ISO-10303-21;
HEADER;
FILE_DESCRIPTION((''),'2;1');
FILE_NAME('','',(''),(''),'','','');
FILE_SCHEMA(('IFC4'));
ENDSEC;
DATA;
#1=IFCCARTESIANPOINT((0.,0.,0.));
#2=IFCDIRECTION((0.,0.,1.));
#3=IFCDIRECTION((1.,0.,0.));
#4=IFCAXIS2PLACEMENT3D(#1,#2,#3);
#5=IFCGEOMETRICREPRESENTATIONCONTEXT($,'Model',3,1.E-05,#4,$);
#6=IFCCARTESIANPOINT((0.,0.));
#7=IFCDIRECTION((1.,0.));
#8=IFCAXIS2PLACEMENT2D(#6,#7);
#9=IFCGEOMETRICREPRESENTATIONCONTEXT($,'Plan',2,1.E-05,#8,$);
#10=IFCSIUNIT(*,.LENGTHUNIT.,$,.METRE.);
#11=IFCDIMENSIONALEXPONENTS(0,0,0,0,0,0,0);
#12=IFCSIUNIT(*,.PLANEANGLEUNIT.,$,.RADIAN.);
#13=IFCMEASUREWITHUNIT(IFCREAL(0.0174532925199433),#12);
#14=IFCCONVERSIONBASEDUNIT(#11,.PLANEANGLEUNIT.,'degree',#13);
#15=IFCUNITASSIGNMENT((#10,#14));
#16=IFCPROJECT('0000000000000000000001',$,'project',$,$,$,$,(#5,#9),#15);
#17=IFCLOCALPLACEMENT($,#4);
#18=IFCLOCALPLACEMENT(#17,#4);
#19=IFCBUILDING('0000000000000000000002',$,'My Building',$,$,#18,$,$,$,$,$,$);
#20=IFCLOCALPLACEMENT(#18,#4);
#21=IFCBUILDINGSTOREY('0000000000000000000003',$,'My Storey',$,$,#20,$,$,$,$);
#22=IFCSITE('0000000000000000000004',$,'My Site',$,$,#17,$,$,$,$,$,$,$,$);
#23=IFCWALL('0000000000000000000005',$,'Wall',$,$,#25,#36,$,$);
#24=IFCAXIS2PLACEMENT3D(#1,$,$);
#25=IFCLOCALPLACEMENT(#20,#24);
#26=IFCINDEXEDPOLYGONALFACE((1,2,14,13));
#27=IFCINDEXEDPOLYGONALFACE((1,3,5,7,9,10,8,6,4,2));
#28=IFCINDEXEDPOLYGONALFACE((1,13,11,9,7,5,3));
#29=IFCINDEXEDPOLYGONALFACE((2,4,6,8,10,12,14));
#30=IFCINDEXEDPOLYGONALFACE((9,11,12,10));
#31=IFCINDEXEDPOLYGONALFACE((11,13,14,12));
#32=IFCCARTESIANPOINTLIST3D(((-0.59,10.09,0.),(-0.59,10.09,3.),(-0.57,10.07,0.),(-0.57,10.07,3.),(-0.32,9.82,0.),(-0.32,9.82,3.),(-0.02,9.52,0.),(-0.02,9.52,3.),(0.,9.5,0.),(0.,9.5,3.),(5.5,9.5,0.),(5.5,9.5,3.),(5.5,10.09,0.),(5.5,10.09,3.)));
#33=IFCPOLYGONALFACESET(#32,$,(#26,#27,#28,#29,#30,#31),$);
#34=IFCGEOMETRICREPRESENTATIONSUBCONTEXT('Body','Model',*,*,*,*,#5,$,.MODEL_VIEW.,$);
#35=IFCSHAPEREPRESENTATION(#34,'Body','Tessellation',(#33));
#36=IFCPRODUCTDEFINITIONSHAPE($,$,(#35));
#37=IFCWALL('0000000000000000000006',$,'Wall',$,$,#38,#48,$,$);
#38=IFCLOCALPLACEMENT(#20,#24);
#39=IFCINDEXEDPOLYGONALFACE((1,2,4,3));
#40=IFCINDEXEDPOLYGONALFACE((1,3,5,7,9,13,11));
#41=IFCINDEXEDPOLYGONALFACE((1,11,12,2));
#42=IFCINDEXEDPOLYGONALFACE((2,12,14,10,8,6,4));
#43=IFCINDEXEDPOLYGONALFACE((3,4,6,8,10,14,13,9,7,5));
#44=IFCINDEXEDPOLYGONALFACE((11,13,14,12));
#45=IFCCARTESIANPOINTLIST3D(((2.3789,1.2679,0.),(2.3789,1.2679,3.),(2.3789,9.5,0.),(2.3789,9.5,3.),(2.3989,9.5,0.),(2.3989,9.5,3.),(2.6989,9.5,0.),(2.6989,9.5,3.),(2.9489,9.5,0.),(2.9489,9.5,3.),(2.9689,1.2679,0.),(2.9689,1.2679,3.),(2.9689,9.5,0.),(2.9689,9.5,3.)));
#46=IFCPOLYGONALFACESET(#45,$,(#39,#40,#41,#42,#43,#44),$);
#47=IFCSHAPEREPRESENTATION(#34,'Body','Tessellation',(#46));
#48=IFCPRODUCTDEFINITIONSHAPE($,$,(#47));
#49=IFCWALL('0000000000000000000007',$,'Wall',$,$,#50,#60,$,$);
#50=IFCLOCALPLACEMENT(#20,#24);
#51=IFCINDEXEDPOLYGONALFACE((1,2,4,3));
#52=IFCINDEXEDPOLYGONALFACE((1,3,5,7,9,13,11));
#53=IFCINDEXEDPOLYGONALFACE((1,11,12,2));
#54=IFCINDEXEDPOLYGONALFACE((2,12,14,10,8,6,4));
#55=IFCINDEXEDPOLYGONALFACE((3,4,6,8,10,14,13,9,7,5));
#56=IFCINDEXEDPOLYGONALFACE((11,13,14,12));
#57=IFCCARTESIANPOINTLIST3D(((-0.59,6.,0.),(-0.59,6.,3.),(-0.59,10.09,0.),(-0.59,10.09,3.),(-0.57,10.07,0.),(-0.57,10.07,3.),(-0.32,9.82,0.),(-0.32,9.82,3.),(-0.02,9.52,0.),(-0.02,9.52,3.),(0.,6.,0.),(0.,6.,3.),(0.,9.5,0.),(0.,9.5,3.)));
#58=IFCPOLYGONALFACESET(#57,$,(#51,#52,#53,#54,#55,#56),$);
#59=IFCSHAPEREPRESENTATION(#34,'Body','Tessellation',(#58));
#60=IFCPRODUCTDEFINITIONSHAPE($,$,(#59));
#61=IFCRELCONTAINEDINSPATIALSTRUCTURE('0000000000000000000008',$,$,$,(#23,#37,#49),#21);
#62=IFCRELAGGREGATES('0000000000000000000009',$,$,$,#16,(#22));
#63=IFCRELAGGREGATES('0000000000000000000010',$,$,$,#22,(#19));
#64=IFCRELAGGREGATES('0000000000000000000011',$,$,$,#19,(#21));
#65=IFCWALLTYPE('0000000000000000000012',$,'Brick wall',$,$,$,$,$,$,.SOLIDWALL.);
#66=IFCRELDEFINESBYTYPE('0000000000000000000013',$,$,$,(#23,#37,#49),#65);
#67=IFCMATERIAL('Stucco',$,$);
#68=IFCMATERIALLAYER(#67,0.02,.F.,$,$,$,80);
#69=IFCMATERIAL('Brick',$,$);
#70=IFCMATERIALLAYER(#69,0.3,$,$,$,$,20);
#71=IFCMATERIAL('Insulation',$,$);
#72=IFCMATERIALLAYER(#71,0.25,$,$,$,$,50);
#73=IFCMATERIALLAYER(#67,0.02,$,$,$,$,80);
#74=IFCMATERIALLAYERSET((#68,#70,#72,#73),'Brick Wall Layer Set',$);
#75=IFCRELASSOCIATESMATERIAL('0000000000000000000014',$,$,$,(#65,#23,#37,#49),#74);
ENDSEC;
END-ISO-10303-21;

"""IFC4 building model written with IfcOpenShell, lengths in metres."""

from ifc_helpers import new_model, entity, si_unit, converted_unit, frame, origin_with_axes, origin_2d_with_axis, place, context, subcontext, project, spatial, line, indexed_curve, outline, extrude, material, layer, layer_set, layer_usage, type_object, element, save


model = new_model("IFC4")

# Units and contexts
model_context = context("Model", 3, precision=1e-05, world=origin_with_axes())
plan_context = context("Plan", 2, precision=1e-05, world=origin_2d_with_axis())
body_context = subcontext(model_context, "Body", "Model", "MODEL_VIEW")
ifc_project = project(units=[si_unit("LENGTHUNIT", "METRE"), converted_unit("PLANEANGLEUNIT", "degree", entity("IfcReal", 0.0174532925199433), si_unit("PLANEANGLEUNIT", "RADIAN"), dimensions=[0, 0, 0, 0, 0, 0, 0])], contexts=[model_context, plan_context])

# Site, building, storey
site_placement = place(None, origin_with_axes())
site = spatial("IfcSite", under=ifc_project, at=site_placement, Name="My Site")
building_placement = place(site_placement, origin_with_axes())
building = spatial("IfcBuilding", under=site, at=building_placement, Name="My Building")
storey_placement = place(building_placement, origin_with_axes())
storey = spatial("IfcBuildingStorey", under=building, at=storey_placement, Name="My Storey")

# Walls
ifc_material_1 = material(Name="Stucco")
ifc_layer_1 = layer(ifc_material_1, 0.02, ventilated=False, Priority=80)
ifc_material_2 = material(Name="Brick")
ifc_layer_2 = layer(ifc_material_2, 0.3, Priority=20)
ifc_material_3 = material(Name="Insulation")
ifc_layer_3 = layer(ifc_material_3, 0.25, Priority=50)
ifc_layer_4 = layer(ifc_material_1, 0.02, Priority=80)
ifc_layer_set = layer_set([ifc_layer_1, ifc_layer_2, ifc_layer_3, ifc_layer_4], Name="Brick Wall Layer Set")
ifc_layer_usage_1 = layer_usage(ifc_layer_set, "AXIS2", "POSITIVE", 0.0)
wall_type = type_object("IfcWallType", Name="Brick wall", PredefinedType="SOLIDWALL", material=ifc_layer_set)
wall_1_placement = place(storey_placement, frame((0.0, 9.5, 0.0), z_axis=(0.0, 0.0, 1.0), x_axis=(1.0, 0.0, 0.0)))
element("IfcWall", 1, at=wall_1_placement, inside=storey, type_object=wall_type, material=ifc_layer_usage_1, Name="Wall", context=body_context, shape_type="SweptSolid", body=[
    extrude(outline(indexed_curve([(0.0, 0.0), (-0.02, 0.02), (-0.32, 0.32), (-0.57, 0.57), (-0.59, 0.59), (5.5, 0.59), (5.5, 0.0)], segments=[line(1, 2, 3, 4, 5, 6, 7, 1)])), origin_with_axes(), (0.0, 0.0, 1.0), 3.0),
])
ifc_layer_usage_2 = layer_usage(ifc_layer_set, "AXIS2", "NEGATIVE", 0.0)
wall_2_placement = place(storey_placement, frame((2.3789, 1.2679, 0.0), z_axis=(0.0, 0.0, 1.0), x_axis=(0.0, 1.0, 0.0)))
element("IfcWall", 2, at=wall_2_placement, inside=storey, type_object=wall_type, material=ifc_layer_usage_2, Name="Wall", context=body_context, shape_type="SweptSolid", body=[
    extrude(outline(indexed_curve([(0.0, -0.59), (0.0, 0.0), (8.2321, 0.0), (8.2321, -0.02), (8.2321, -0.32), (8.2321, -0.57), (8.2321, -0.59)], segments=[line(1, 2, 3, 4, 5, 6, 7, 1)])), origin_with_axes(), (0.0, 0.0, 1.0), 3.0),
])
ifc_layer_usage_3 = layer_usage(ifc_layer_set, "AXIS2", "POSITIVE", 0.0)
wall_3_placement = place(storey_placement, frame((0.0, 6.0, 0.0), z_axis=(0.0, 0.0, 1.0), x_axis=(0.0, 1.0, 0.0)))
element("IfcWall", 3, at=wall_3_placement, inside=storey, type_object=wall_type, material=ifc_layer_usage_3, Name="Wall", context=body_context, shape_type="SweptSolid", body=[
    extrude(outline(indexed_curve([(0.0, 0.0), (0.0, 0.59), (4.09, 0.59), (4.07, 0.57), (3.82, 0.32), (3.52, 0.02), (3.5, 0.0)], segments=[line(1, 2, 3, 4, 5, 6, 7, 1)])), origin_with_axes(), (0.0, 0.0, 1.0), 3.0),
])

save(model, "model.ifc")
